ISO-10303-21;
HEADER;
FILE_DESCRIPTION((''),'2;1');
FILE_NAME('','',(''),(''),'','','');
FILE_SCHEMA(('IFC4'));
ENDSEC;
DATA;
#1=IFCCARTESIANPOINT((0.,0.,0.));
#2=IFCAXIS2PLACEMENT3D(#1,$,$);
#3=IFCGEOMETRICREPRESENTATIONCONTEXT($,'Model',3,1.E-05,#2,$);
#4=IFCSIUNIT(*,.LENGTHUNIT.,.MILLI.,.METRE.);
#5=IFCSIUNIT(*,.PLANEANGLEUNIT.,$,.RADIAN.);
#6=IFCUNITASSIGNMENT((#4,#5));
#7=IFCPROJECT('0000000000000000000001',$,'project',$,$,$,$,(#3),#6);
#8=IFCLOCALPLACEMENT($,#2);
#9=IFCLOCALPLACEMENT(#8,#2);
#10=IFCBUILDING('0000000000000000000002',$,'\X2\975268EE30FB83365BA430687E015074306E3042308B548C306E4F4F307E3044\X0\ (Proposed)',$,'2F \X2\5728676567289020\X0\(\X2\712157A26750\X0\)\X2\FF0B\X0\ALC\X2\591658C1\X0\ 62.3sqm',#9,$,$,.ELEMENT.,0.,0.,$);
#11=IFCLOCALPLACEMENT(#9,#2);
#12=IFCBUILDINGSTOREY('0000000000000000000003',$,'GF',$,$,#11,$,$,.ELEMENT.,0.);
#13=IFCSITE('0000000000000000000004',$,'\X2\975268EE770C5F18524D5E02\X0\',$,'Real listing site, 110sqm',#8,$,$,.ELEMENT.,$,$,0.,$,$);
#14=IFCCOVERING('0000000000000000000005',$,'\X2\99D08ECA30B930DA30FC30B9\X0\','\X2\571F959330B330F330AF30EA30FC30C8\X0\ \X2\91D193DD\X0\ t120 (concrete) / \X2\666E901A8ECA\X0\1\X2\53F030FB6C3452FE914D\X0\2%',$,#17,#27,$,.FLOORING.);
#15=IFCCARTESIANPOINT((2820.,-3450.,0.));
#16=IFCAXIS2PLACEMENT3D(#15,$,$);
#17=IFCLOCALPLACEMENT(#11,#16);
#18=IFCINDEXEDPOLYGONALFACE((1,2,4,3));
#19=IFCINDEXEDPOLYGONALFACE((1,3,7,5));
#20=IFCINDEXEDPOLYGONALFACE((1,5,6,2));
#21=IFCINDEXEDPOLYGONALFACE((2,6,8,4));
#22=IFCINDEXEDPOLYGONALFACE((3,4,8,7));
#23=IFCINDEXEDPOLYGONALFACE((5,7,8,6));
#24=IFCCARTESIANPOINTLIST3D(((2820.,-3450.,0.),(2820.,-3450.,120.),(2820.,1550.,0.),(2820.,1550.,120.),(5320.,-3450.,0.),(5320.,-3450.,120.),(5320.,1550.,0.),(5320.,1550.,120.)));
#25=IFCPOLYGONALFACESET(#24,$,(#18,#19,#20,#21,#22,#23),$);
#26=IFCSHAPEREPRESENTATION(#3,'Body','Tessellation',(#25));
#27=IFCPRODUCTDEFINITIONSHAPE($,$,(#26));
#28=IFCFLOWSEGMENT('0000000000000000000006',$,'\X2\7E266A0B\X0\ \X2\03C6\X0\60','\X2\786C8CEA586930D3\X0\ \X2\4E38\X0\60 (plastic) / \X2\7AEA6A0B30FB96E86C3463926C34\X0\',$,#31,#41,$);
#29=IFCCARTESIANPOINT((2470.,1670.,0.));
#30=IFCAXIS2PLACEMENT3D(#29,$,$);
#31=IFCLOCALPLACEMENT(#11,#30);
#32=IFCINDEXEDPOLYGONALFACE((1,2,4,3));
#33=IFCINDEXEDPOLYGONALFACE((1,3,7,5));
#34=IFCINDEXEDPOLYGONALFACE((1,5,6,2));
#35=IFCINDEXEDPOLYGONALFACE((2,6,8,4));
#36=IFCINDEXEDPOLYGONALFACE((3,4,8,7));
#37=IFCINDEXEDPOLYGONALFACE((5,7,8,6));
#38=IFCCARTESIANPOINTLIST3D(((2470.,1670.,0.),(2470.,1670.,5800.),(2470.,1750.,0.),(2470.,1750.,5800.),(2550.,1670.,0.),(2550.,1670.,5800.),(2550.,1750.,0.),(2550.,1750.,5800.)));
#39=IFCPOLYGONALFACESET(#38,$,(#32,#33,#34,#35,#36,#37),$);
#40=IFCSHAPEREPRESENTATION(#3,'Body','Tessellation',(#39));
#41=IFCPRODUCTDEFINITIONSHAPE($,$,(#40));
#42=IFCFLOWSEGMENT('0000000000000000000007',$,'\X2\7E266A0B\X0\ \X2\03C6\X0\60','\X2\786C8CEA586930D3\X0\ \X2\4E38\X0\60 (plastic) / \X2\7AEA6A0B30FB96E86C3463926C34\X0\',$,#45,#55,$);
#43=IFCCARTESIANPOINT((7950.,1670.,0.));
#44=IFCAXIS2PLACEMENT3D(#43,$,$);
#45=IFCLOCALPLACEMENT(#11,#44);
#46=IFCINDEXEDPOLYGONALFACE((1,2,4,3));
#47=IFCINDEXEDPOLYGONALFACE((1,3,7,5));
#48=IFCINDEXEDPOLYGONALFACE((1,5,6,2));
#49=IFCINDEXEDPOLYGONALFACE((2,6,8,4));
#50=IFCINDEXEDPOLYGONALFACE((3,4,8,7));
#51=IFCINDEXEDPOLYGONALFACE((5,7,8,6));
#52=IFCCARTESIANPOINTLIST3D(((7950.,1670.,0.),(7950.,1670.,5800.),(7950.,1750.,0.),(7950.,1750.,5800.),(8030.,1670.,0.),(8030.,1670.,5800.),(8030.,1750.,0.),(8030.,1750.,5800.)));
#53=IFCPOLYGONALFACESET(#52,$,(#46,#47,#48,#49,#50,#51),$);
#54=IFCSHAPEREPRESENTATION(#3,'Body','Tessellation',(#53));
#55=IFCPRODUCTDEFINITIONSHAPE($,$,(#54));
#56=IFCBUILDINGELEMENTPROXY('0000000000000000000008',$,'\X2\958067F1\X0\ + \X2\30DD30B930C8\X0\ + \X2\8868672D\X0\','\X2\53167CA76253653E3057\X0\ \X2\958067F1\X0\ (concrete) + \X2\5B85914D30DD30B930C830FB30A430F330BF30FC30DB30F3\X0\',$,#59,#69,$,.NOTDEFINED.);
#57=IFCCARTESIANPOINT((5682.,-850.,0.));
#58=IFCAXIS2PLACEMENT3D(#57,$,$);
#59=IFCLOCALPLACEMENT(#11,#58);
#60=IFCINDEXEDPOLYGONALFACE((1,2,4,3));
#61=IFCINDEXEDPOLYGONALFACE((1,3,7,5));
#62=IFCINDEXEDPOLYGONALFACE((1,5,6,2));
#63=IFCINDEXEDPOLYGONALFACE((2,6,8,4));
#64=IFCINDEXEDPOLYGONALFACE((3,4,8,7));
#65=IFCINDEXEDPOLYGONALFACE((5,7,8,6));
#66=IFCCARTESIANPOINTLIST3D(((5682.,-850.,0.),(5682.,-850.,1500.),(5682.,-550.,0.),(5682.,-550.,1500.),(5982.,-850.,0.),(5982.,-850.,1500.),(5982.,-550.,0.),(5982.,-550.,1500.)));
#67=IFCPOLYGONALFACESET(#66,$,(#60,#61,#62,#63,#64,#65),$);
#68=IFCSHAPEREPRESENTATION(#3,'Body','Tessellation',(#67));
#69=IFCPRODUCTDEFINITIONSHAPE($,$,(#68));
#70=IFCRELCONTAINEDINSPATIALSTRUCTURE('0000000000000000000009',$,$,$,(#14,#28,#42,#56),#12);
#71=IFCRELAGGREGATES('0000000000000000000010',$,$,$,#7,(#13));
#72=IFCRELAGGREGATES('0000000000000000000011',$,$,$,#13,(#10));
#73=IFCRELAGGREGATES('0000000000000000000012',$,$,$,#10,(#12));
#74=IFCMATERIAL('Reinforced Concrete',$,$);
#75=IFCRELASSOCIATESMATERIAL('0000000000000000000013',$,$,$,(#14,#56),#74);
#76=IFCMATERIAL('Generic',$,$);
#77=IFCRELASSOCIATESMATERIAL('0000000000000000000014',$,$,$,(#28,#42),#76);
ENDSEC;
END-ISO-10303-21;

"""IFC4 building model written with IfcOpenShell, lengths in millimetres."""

from ifc_helpers import new_model, si_unit, frame, frame_2d, origin, place, context, project, spatial, rectangle, extrude, material, element, save


model = new_model("IFC4")

# Units and contexts
model_context = context("Model", 3, precision=1e-05, world=origin())
ifc_project = project(units=[si_unit("LENGTHUNIT", "METRE", prefix="MILLI"), si_unit("PLANEANGLEUNIT", "RADIAN")], contexts=[model_context])

# Site, building, storey
site_placement = place(None, origin())
site = spatial("IfcSite", under=ifc_project, at=site_placement, Name="青森県弘前市", ObjectType="Real listing site, 110sqm", CompositionType="ELEMENT", RefElevation=0.0)
building_placement = place(site_placement, origin())
building = spatial("IfcBuilding", under=site, at=building_placement, Name="青森・茶室と縁側のある和の住まい (Proposed)", ObjectType="2F 在来木造(無垢材)＋ALC外壁 62.3sqm", CompositionType="ELEMENT", ElevationOfRefHeight=0.0, ElevationOfTerrain=0.0)
storey_placement = place(building_placement, origin())
storey = spatial("IfcBuildingStorey", under=building, at=storey_placement, Name="GF", CompositionType="ELEMENT", Elevation=0.0)

# Shared definitions
ifc_material_1 = material(Name="Reinforced Concrete")

# Covering
covering_1_placement = place(storey_placement, frame((2820.0, -3450.0, 0.0)))
element("IfcCovering", 1, at=covering_1_placement, inside=storey, material=ifc_material_1, Name="駐車スペース", Description="土間コンクリート 金鏝 t120 (concrete) / 普通車1台・水勾配2%", PredefinedType="FLOORING", context=model_context, shape_type="SweptSolid", body=[
    extrude(rectangle(XDim=2500.0, YDim=5000.0, at=frame_2d((1250.0, 2500.0))), frame((2820.0, -3450.0, 0.0)), (0.0, 0.0, 1.0), 120.0),
])

# Flow segments
ifc_material_2 = material(Name="Generic")
flow_segment_1_placement = place(storey_placement, frame((2470.0, 1670.0, 0.0)))
element("IfcFlowSegment", 2, at=flow_segment_1_placement, inside=storey, material=ifc_material_2, Name="縦樋 φ60", Description="硬質塩ビ 丸60 (plastic) / 竪樋・雨水排水", context=model_context, shape_type="SweptSolid", body=[
    extrude(rectangle(XDim=80.0, YDim=80.0, at=frame_2d((40.0, 40.0))), frame((2470.0, 1670.0, 0.0)), (0.0, 0.0, 1.0), 5800.0),
])
flow_segment_2_placement = place(storey_placement, frame((7950.0, 1670.0, 0.0)))
element("IfcFlowSegment", 3, at=flow_segment_2_placement, inside=storey, material=ifc_material_2, Name="縦樋 φ60", Description="硬質塩ビ 丸60 (plastic) / 竪樋・雨水排水", context=model_context, shape_type="SweptSolid", body=[
    extrude(rectangle(XDim=80.0, YDim=80.0, at=frame_2d((40.0, 40.0))), frame((7950.0, 1670.0, 0.0)), (0.0, 0.0, 1.0), 5800.0),
])

# Building element proxy
proxy_placement = place(storey_placement, frame((5682.0, -850.0, 0.0)))
element("IfcBuildingElementProxy", 4, at=proxy_placement, inside=storey, material=ifc_material_1, Name="門柱 + ポスト + 表札", Description="化粧打放し 門柱 (concrete) + 宅配ポスト・インターホン", PredefinedType="NOTDEFINED", context=model_context, shape_type="SweptSolid", body=[
    extrude(rectangle(XDim=300.0, YDim=300.0, at=frame_2d((150.0, 150.0))), frame((5682.0, -850.0, 0.0)), (0.0, 0.0, 1.0), 1500.0),
])

save(model, "model.ifc")
